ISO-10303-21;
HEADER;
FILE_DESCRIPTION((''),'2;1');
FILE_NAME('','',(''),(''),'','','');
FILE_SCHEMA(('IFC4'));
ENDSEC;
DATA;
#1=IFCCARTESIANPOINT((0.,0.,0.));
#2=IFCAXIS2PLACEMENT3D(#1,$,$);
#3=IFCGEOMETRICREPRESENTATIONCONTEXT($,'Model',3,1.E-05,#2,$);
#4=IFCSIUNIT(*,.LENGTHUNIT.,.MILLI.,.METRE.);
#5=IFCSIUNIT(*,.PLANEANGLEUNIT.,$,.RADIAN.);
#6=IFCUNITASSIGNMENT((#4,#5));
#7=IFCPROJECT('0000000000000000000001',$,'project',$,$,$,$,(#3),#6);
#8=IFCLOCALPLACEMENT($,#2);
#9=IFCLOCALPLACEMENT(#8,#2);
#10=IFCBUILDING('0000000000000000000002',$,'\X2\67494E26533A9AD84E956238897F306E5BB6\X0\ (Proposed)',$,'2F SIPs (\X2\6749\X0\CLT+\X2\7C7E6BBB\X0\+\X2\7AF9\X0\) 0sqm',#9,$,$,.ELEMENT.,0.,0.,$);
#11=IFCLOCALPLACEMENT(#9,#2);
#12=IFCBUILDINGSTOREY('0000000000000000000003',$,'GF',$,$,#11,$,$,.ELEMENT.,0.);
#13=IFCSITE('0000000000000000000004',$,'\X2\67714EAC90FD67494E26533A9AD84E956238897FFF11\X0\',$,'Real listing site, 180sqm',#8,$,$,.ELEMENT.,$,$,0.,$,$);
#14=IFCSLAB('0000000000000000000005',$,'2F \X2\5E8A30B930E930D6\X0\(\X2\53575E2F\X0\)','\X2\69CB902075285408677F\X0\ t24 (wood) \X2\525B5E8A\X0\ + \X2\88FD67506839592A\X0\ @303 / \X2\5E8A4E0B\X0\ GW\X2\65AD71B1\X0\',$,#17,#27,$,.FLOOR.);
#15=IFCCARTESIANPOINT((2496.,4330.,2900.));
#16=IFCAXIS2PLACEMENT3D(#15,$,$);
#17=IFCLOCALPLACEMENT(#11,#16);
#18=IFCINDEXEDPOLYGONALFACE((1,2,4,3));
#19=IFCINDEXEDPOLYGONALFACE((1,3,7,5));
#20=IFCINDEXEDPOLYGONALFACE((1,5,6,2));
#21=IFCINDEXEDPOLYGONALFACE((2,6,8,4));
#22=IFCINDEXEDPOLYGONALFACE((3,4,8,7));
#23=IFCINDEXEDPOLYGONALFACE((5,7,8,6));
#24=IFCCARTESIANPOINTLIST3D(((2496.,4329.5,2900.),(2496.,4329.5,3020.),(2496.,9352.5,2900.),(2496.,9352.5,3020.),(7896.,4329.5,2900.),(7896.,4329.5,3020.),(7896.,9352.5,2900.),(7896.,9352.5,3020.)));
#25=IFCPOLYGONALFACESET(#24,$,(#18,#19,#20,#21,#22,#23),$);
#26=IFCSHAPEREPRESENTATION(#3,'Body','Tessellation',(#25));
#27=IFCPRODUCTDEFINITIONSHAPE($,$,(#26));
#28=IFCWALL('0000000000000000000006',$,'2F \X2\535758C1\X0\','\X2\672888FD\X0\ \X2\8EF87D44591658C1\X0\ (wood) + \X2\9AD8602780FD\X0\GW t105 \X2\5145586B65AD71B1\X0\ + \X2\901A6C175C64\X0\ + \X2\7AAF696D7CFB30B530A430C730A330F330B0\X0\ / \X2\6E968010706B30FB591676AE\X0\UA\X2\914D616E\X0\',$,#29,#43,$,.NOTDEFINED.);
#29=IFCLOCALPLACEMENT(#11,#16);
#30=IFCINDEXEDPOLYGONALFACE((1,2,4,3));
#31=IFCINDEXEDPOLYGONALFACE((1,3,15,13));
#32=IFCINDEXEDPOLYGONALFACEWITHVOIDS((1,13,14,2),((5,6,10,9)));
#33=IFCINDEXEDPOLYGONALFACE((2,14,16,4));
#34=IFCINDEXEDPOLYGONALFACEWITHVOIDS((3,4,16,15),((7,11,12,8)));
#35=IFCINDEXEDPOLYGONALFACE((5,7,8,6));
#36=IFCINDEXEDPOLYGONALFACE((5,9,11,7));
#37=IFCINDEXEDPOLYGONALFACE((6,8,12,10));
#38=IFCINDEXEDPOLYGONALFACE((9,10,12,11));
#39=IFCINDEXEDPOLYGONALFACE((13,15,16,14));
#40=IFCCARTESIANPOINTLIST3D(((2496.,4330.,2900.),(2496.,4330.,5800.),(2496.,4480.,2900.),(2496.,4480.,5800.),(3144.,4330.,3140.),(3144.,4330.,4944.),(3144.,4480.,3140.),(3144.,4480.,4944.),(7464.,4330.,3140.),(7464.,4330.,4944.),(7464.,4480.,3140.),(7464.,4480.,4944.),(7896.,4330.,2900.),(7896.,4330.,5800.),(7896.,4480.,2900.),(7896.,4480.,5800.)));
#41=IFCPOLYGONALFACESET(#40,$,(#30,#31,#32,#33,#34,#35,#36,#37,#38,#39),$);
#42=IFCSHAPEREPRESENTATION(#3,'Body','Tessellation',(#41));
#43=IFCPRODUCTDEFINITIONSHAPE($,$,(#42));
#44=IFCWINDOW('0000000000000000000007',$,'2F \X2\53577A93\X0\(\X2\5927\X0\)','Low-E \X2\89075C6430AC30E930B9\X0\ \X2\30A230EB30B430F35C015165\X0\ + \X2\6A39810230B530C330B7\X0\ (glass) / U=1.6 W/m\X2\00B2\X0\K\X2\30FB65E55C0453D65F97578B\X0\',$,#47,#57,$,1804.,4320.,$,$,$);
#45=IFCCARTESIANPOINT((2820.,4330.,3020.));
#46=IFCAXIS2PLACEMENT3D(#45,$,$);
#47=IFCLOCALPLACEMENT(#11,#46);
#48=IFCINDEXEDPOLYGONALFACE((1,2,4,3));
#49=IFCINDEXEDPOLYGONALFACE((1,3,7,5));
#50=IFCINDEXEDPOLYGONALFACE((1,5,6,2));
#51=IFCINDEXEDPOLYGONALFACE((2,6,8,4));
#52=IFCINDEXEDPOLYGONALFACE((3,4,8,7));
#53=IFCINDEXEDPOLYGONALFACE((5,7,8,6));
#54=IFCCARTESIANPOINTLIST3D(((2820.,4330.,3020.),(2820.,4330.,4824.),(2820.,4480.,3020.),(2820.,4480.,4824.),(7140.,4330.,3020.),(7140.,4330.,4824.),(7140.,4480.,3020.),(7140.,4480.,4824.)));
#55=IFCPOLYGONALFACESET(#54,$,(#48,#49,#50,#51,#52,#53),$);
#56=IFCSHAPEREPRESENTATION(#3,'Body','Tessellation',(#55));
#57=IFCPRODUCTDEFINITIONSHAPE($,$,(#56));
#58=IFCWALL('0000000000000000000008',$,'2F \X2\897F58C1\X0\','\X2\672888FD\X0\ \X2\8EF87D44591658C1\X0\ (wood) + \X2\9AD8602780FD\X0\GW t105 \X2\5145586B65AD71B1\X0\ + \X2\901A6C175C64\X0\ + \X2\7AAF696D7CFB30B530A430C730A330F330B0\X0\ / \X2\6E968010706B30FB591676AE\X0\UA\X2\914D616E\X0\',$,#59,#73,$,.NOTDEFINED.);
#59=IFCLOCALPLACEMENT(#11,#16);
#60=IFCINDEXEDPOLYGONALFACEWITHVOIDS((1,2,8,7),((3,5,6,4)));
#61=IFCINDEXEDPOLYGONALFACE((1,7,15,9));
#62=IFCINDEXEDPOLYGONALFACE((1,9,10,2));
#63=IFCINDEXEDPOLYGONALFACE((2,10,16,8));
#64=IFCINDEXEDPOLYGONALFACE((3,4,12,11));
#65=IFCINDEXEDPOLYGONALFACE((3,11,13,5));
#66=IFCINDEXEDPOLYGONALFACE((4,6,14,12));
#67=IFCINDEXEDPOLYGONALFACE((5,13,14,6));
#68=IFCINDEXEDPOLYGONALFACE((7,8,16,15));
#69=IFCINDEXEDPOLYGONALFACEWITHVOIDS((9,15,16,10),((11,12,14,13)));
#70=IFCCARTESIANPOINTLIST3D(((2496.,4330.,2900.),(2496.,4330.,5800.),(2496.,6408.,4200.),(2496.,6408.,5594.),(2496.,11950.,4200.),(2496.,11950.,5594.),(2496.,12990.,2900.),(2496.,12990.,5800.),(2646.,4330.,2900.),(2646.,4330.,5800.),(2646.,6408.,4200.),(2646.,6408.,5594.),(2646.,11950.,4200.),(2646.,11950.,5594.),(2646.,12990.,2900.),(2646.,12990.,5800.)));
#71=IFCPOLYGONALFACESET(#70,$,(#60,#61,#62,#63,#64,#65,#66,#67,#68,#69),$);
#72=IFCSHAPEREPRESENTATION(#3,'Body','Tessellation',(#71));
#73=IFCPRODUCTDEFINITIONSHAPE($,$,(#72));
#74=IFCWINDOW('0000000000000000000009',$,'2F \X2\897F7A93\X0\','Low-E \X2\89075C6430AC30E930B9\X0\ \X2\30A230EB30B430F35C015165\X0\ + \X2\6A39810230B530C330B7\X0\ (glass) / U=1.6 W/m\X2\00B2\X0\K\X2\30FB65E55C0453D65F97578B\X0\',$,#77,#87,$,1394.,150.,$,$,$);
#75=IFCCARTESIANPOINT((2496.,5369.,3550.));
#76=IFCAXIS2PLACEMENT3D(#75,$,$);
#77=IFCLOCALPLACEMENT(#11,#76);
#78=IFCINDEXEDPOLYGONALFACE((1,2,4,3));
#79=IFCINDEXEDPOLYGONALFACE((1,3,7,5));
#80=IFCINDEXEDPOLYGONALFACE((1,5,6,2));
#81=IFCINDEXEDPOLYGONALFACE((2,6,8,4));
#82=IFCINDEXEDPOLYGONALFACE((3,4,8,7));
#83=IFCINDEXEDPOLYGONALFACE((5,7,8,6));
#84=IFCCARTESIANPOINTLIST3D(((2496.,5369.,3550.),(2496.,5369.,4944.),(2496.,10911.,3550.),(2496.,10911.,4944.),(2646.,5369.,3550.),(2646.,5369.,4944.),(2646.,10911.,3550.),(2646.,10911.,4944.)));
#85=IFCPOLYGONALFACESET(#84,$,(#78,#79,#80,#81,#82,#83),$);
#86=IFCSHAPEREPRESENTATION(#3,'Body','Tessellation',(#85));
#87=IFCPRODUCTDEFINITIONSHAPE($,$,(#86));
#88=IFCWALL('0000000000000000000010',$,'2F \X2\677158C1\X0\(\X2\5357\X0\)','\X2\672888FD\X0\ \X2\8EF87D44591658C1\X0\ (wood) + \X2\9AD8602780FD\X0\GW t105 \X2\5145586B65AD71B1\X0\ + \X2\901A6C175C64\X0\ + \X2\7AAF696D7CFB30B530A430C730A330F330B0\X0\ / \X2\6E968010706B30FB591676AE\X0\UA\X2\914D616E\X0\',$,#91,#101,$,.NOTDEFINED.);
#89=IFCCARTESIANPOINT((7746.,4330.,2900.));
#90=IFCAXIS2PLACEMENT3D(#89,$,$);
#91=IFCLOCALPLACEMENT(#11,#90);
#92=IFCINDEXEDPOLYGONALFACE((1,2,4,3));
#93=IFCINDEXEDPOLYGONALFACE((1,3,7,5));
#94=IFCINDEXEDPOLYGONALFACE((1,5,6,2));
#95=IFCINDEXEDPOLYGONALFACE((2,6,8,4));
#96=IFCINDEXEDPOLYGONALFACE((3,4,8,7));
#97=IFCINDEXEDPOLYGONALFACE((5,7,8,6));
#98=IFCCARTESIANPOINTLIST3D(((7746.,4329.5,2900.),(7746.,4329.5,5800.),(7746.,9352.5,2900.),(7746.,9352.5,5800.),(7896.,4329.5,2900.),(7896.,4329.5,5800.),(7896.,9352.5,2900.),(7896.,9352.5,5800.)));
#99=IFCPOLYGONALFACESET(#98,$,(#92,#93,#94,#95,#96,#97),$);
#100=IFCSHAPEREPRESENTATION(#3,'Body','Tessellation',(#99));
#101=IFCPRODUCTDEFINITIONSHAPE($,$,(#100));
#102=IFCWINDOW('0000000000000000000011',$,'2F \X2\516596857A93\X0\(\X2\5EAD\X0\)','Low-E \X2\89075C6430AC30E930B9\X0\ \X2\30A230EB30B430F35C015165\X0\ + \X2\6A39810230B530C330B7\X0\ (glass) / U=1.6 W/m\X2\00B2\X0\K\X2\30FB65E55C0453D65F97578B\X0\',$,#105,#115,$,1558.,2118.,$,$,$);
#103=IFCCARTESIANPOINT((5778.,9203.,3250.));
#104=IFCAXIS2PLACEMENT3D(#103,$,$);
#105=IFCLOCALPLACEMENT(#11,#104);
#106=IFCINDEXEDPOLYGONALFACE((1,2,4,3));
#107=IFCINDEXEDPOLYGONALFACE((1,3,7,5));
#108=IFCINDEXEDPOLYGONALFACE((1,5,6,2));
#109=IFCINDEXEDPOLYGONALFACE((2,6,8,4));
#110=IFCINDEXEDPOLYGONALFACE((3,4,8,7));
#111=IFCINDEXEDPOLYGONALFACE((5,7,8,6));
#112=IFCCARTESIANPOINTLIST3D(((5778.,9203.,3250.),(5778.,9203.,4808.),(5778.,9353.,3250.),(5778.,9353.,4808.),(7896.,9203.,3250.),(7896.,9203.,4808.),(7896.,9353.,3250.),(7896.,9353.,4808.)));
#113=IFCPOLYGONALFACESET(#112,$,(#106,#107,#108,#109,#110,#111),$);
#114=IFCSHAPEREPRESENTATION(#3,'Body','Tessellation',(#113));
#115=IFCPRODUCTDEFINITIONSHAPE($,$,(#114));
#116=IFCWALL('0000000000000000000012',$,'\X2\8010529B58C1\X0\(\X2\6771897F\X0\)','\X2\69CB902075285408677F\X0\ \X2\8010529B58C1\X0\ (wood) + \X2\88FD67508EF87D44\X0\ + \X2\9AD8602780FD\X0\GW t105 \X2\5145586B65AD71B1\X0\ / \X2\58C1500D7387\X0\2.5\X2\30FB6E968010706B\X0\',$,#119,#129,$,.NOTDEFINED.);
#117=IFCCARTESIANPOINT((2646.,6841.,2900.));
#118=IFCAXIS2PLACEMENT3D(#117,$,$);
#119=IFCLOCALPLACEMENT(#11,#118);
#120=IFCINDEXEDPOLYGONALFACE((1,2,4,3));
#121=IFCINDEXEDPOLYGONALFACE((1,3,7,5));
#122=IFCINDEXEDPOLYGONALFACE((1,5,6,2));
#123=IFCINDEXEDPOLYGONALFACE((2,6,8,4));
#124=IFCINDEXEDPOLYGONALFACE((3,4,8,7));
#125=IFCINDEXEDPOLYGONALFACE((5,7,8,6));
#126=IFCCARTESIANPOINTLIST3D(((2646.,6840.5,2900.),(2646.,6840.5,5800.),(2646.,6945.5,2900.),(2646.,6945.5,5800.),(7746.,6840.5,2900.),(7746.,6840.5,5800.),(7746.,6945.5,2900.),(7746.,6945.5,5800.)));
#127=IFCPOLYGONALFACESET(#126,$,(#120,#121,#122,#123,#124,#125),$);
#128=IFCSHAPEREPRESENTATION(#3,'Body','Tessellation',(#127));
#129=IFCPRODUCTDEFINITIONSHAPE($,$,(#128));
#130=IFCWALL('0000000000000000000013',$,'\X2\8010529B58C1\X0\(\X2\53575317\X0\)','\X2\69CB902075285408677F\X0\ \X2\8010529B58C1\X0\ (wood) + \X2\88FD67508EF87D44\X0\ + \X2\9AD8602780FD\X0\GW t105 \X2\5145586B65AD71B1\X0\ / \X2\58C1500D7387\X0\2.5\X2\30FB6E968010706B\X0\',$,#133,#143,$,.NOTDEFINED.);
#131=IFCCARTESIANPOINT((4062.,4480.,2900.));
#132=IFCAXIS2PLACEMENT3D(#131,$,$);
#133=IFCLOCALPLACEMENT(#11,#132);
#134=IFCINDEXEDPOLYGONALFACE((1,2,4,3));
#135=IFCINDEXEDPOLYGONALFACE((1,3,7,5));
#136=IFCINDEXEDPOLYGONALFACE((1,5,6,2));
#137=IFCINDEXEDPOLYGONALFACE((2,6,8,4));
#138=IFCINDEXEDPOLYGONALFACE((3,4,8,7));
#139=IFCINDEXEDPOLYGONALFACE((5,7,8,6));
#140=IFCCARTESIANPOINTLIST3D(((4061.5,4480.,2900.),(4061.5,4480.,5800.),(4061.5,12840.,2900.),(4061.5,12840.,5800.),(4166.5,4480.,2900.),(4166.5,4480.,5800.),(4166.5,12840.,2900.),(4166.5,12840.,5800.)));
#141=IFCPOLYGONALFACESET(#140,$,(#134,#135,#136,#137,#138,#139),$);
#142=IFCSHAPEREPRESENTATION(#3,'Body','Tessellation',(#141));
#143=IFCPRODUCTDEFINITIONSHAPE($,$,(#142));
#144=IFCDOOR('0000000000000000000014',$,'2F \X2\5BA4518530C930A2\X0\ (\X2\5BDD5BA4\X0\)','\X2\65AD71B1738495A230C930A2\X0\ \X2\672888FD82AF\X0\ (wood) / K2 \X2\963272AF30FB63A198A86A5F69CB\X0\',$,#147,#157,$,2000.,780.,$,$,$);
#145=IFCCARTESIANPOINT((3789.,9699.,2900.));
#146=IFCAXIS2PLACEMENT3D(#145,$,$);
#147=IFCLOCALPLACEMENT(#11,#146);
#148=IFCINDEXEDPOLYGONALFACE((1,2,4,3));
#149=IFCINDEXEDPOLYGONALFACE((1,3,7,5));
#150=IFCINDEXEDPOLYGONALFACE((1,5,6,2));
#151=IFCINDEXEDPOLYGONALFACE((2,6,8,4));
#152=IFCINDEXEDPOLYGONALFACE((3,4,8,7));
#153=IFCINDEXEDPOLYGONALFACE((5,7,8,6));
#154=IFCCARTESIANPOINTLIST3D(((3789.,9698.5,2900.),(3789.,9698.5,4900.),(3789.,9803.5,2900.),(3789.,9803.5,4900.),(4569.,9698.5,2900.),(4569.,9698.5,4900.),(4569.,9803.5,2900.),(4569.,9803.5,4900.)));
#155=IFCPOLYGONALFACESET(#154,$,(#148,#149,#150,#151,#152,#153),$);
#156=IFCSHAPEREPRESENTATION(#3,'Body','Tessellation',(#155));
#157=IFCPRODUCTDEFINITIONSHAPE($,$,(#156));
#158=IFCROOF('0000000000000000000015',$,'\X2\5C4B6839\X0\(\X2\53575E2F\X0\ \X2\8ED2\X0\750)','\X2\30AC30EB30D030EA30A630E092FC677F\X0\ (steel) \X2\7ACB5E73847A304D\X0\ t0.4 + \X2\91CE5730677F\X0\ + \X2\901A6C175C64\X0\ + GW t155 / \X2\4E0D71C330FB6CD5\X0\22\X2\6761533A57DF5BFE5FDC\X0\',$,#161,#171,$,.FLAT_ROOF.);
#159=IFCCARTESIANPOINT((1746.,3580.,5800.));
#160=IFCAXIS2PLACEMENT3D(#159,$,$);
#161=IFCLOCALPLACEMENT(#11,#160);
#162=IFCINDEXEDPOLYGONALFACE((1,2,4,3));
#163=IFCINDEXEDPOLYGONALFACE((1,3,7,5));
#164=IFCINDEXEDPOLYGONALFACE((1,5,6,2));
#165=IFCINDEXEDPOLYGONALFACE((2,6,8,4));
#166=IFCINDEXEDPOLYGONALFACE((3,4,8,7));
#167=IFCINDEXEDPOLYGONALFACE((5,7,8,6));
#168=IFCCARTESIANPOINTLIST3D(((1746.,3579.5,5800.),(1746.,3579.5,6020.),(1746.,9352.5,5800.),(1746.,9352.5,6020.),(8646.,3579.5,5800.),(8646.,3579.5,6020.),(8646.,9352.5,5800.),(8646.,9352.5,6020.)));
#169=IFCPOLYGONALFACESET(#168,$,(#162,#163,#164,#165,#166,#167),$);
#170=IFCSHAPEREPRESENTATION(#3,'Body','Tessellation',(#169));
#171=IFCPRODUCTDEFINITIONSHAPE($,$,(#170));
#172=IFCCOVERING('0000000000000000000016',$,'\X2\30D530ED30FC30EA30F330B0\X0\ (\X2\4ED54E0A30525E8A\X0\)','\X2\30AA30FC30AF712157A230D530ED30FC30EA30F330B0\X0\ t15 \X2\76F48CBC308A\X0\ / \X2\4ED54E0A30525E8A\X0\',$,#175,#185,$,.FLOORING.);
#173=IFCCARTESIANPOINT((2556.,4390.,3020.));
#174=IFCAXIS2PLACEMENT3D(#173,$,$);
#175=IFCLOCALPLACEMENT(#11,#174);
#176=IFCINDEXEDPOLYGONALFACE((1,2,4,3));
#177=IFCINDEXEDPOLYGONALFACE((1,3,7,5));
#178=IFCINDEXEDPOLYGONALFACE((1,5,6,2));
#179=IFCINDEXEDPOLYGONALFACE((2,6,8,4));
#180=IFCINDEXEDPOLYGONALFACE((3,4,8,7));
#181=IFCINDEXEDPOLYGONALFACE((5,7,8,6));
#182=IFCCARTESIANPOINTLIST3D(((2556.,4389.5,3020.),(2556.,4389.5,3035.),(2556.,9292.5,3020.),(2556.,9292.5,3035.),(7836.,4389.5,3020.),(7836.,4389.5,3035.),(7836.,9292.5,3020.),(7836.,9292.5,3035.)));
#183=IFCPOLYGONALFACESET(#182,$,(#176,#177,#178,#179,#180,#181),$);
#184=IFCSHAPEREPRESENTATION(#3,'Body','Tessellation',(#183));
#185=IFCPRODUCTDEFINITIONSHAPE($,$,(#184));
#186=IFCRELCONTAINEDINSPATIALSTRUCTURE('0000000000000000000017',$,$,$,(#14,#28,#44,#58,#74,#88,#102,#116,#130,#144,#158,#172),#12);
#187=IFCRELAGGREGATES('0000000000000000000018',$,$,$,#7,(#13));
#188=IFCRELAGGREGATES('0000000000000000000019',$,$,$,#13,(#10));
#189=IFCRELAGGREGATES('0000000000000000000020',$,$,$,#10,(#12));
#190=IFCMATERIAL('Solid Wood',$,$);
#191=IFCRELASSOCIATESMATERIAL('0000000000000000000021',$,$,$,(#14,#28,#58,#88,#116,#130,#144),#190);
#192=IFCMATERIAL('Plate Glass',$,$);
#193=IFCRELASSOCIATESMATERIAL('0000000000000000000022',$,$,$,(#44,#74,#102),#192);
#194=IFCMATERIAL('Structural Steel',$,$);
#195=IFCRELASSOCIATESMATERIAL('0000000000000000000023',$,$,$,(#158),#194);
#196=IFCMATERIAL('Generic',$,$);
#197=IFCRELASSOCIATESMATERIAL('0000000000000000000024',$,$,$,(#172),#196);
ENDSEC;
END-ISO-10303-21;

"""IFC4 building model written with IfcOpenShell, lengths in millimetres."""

from ifc_helpers import new_model, si_unit, frame, frame_2d, origin, place, context, project, spatial, rectangle, extrude, material, element, fill, save


model = new_model("IFC4")

# Units and contexts
model_context = context("Model", 3, precision=1e-05, world=origin())
ifc_project = project(units=[si_unit("LENGTHUNIT", "METRE", prefix="MILLI"), si_unit("PLANEANGLEUNIT", "RADIAN")], contexts=[model_context])

# Site, building, storey
site_placement = place(None, origin())
site = spatial("IfcSite", under=ifc_project, at=site_placement, Name="東京都杉並区高井戸西１", ObjectType="Real listing site, 180sqm", CompositionType="ELEMENT", RefElevation=0.0)
building_placement = place(site_placement, origin())
building = spatial("IfcBuilding", under=site, at=building_placement, Name="杉並区高井戸西の家 (Proposed)", ObjectType="2F SIPs (杉CLT+籾殻+竹) 0sqm", CompositionType="ELEMENT", ElevationOfRefHeight=0.0, ElevationOfTerrain=0.0)
storey_placement = place(building_placement, origin())
storey = spatial("IfcBuildingStorey", under=building, at=storey_placement, Name="GF", CompositionType="ELEMENT", Elevation=0.0)

# Slab
ifc_material_1 = material(Name="Solid Wood")
slab_placement = place(storey_placement, frame((2496.0, 4330.0, 2900.0)))
element("IfcSlab", 1, at=slab_placement, inside=storey, material=ifc_material_1, Name="2F 床スラブ(南帯)", Description="構造用合板 t24 (wood) 剛床 + 製材根太 @303 / 床下 GW断熱", PredefinedType="FLOOR", context=model_context, shape_type="SweptSolid", body=[
    extrude(rectangle(XDim=5400.0, YDim=5023.0, at=frame_2d((2700.0, 2511.0))), frame((2496.0, 4330.0, 2900.0)), (0.0, 0.0, 1.0), 120.0),
])

# Walls, openings, windows
wall_1_placement = place(storey_placement, frame((2496.0, 4330.0, 2900.0)))
wall_1 = element("IfcWall", 2, at=wall_1_placement, inside=storey, material=ifc_material_1, Name="2F 南壁", Description="木製 軸組外壁 (wood) + 高性能GW t105 充填断熱 + 通気層 + 窯業系サイディング / 準耐火・外皮UA配慮", PredefinedType="NOTDEFINED", context=model_context, shape_type="SweptSolid", body=[
    extrude(rectangle(XDim=5400.0, YDim=150.0, at=frame_2d((2700.0, 75.0))), frame((2496.0, 4330.0, 2900.0)), (0.0, 0.0, 1.0), 2900.0),
])
opening_1_placement = place(storey_placement, frame((2820.0, 4330.0, 3020.0)))
opening_1 = element("IfcOpeningElement", 3, at=opening_1_placement, cuts=wall_1, PredefinedType="NOTDEFINED", context=model_context, shape_type="SweptSolid", body=[
    extrude(rectangle(XDim=4320.0, YDim=150.0, at=frame_2d((2160.0, 75.0))), frame((2820.0, 4330.0, 3020.0)), (0.0, 0.0, 1.0), 1804.0),
])
ifc_material_2 = material(Name="Plate Glass")
window_1_placement = place(storey_placement, frame((2820.0, 4330.0, 3020.0)))
window_1 = element("IfcWindow", 4, at=window_1_placement, inside=storey, material=ifc_material_2, Name="2F 南窓(大)", Description="Low-E 複層ガラス アルゴン封入 + 樹脂サッシ (glass) / U=1.6 W/m²K・日射取得型", OverallHeight=1804.0, OverallWidth=4320.0, context=model_context, shape_type="SweptSolid", body=[
    extrude(rectangle(XDim=4320.0, YDim=150.0, at=frame_2d((2160.0, 75.0))), frame((2820.0, 4330.0, 3020.0)), (0.0, 0.0, 1.0), 1804.0),
])
fill(opening_1, window_1)
wall_2_placement = place(storey_placement, frame((2496.0, 4330.0, 2900.0)))
wall_2 = element("IfcWall", 5, at=wall_2_placement, inside=storey, material=ifc_material_1, Name="2F 西壁", Description="木製 軸組外壁 (wood) + 高性能GW t105 充填断熱 + 通気層 + 窯業系サイディング / 準耐火・外皮UA配慮", PredefinedType="NOTDEFINED", context=model_context, shape_type="SweptSolid", body=[
    extrude(rectangle(XDim=150.0, YDim=8660.0, at=frame_2d((75.0, 4330.0))), frame((2496.0, 4330.0, 2900.0)), (0.0, 0.0, 1.0), 2900.0),
])
opening_2_placement = place(storey_placement, frame((2496.0, 5369.0, 3550.0)))
opening_2 = element("IfcOpeningElement", 6, at=opening_2_placement, cuts=wall_2, PredefinedType="NOTDEFINED", context=model_context, shape_type="SweptSolid", body=[
    extrude(rectangle(XDim=150.0, YDim=5542.0, at=frame_2d((75.0, 2771.0))), frame((2496.0, 5369.0, 3550.0)), (0.0, 0.0, 1.0), 1394.0),
])
window_2_placement = place(storey_placement, frame((2496.0, 5369.0, 3550.0)))
window_2 = element("IfcWindow", 7, at=window_2_placement, inside=storey, material=ifc_material_2, Name="2F 西窓", Description="Low-E 複層ガラス アルゴン封入 + 樹脂サッシ (glass) / U=1.6 W/m²K・日射取得型", OverallHeight=1394.0, OverallWidth=150.0, context=model_context, shape_type="SweptSolid", body=[
    extrude(rectangle(XDim=150.0, YDim=5542.0, at=frame_2d((75.0, 2771.0))), frame((2496.0, 5369.0, 3550.0)), (0.0, 0.0, 1.0), 1394.0),
])
fill(opening_2, window_2)
wall_3_placement = place(storey_placement, frame((7746.0, 4330.0, 2900.0)))
wall_3 = element("IfcWall", 8, at=wall_3_placement, inside=storey, material=ifc_material_1, Name="2F 東壁(南)", Description="木製 軸組外壁 (wood) + 高性能GW t105 充填断熱 + 通気層 + 窯業系サイディング / 準耐火・外皮UA配慮", PredefinedType="NOTDEFINED", context=model_context, shape_type="SweptSolid", body=[
    extrude(rectangle(XDim=150.0, YDim=5023.0, at=frame_2d((75.0, 2511.0))), frame((7746.0, 4330.0, 2900.0)), (0.0, 0.0, 1.0), 2900.0),
])
opening_3_placement = place(storey_placement, frame((5778.0, 9203.0, 3250.0)))
opening_3 = element("IfcOpeningElement", 9, at=opening_3_placement, cuts=wall_3, PredefinedType="NOTDEFINED", context=model_context, shape_type="SweptSolid", body=[
    extrude(rectangle(XDim=2118.0, YDim=150.0, at=frame_2d((1059.0, 75.0))), frame((5778.0, 9203.0, 3250.0)), (0.0, 0.0, 1.0), 1558.0),
])
window_3_placement = place(storey_placement, frame((5778.0, 9203.0, 3250.0)))
window_3 = element("IfcWindow", 10, at=window_3_placement, inside=storey, material=ifc_material_2, Name="2F 入隅窓(庭)", Description="Low-E 複層ガラス アルゴン封入 + 樹脂サッシ (glass) / U=1.6 W/m²K・日射取得型", OverallHeight=1558.0, OverallWidth=2118.0, context=model_context, shape_type="SweptSolid", body=[
    extrude(rectangle(XDim=2118.0, YDim=150.0, at=frame_2d((1059.0, 75.0))), frame((5778.0, 9203.0, 3250.0)), (0.0, 0.0, 1.0), 1558.0),
])
fill(opening_3, window_3)

# Wall
wall_4_placement = place(storey_placement, frame((2646.0, 6841.0, 2900.0)))
element("IfcWall", 11, at=wall_4_placement, inside=storey, material=ifc_material_1, Name="耐力壁(東西)", Description="構造用合板 耐力壁 (wood) + 製材軸組 + 高性能GW t105 充填断熱 / 壁倍率2.5・準耐火", PredefinedType="NOTDEFINED", context=model_context, shape_type="SweptSolid", body=[
    extrude(rectangle(XDim=5100.0, YDim=105.0, at=frame_2d((2550.0, 52.0))), frame((2646.0, 6841.0, 2900.0)), (0.0, 0.0, 1.0), 2900.0),
])

# Wall, opening, door
wall_5_placement = place(storey_placement, frame((4062.0, 4480.0, 2900.0)))
wall_5 = element("IfcWall", 12, at=wall_5_placement, inside=storey, material=ifc_material_1, Name="耐力壁(南北)", Description="構造用合板 耐力壁 (wood) + 製材軸組 + 高性能GW t105 充填断熱 / 壁倍率2.5・準耐火", PredefinedType="NOTDEFINED", context=model_context, shape_type="SweptSolid", body=[
    extrude(rectangle(XDim=105.0, YDim=8360.0, at=frame_2d((52.0, 4180.0))), frame((4062.0, 4480.0, 2900.0)), (0.0, 0.0, 1.0), 2900.0),
])
opening_4_placement = place(storey_placement, frame((3789.0, 9699.0, 2900.0)))
opening_4 = element("IfcOpeningElement", 13, at=opening_4_placement, cuts=wall_5, PredefinedType="NOTDEFINED", context=model_context, shape_type="SweptSolid", body=[
    extrude(rectangle(XDim=780.0, YDim=105.0, at=frame_2d((390.0, 52.0))), frame((3789.0, 9699.0, 2900.0)), (0.0, 0.0, 1.0), 2000.0),
])
door_placement = place(storey_placement, frame((3789.0, 9699.0, 2900.0)))
door = element("IfcDoor", 14, at=door_placement, inside=storey, material=ifc_material_1, Name="2F 室内ドア (寝室)", Description="断熱玄関ドア 木製芯 (wood) / K2 防犯・採風機構", OverallHeight=2000.0, OverallWidth=780.0, context=model_context, shape_type="SweptSolid", body=[
    extrude(rectangle(XDim=780.0, YDim=105.0, at=frame_2d((390.0, 52.0))), frame((3789.0, 9699.0, 2900.0)), (0.0, 0.0, 1.0), 2000.0),
])
fill(opening_4, door)

# Roof
ifc_material_3 = material(Name="Structural Steel")
for number, where, name in (
    (15, (1746.0, 3580.0, 5800.0), "屋根(南帯 軒750)"),
):
    element("IfcRoof", number, at=place(storey_placement, frame(where)), inside=storey, material=ifc_material_3, Name=name, Description="ガルバリウム鋼板 (steel) 立平葺き t0.4 + 野地板 + 通気層 + GW t155 / 不燃・法22条区域対応", PredefinedType="FLAT_ROOF", context=model_context, shape_type="SweptSolid", body=[
        extrude(rectangle(XDim=6900.0, YDim=5773.0, at=frame_2d((3450.0, 2886.0))), frame((1746.0, 3580.0, 5800.0)), (0.0, 0.0, 1.0), 220.0),
    ])

# Covering
ifc_material_4 = material(Name="Generic")
covering_placement = place(storey_placement, frame((2556.0, 4390.0, 3020.0)))
element("IfcCovering", 16, at=covering_placement, inside=storey, material=ifc_material_4, Name="フローリング (仕上げ床)", Description="オーク無垢フローリング t15 直貼り / 仕上げ床", PredefinedType="FLOORING", context=model_context, shape_type="SweptSolid", body=[
    extrude(rectangle(XDim=5280.0, YDim=4903.0, at=frame_2d((2640.0, 2451.0))), frame((2556.0, 4390.0, 3020.0)), (0.0, 0.0, 1.0), 15.0),
])

save(model, "model.ifc")
